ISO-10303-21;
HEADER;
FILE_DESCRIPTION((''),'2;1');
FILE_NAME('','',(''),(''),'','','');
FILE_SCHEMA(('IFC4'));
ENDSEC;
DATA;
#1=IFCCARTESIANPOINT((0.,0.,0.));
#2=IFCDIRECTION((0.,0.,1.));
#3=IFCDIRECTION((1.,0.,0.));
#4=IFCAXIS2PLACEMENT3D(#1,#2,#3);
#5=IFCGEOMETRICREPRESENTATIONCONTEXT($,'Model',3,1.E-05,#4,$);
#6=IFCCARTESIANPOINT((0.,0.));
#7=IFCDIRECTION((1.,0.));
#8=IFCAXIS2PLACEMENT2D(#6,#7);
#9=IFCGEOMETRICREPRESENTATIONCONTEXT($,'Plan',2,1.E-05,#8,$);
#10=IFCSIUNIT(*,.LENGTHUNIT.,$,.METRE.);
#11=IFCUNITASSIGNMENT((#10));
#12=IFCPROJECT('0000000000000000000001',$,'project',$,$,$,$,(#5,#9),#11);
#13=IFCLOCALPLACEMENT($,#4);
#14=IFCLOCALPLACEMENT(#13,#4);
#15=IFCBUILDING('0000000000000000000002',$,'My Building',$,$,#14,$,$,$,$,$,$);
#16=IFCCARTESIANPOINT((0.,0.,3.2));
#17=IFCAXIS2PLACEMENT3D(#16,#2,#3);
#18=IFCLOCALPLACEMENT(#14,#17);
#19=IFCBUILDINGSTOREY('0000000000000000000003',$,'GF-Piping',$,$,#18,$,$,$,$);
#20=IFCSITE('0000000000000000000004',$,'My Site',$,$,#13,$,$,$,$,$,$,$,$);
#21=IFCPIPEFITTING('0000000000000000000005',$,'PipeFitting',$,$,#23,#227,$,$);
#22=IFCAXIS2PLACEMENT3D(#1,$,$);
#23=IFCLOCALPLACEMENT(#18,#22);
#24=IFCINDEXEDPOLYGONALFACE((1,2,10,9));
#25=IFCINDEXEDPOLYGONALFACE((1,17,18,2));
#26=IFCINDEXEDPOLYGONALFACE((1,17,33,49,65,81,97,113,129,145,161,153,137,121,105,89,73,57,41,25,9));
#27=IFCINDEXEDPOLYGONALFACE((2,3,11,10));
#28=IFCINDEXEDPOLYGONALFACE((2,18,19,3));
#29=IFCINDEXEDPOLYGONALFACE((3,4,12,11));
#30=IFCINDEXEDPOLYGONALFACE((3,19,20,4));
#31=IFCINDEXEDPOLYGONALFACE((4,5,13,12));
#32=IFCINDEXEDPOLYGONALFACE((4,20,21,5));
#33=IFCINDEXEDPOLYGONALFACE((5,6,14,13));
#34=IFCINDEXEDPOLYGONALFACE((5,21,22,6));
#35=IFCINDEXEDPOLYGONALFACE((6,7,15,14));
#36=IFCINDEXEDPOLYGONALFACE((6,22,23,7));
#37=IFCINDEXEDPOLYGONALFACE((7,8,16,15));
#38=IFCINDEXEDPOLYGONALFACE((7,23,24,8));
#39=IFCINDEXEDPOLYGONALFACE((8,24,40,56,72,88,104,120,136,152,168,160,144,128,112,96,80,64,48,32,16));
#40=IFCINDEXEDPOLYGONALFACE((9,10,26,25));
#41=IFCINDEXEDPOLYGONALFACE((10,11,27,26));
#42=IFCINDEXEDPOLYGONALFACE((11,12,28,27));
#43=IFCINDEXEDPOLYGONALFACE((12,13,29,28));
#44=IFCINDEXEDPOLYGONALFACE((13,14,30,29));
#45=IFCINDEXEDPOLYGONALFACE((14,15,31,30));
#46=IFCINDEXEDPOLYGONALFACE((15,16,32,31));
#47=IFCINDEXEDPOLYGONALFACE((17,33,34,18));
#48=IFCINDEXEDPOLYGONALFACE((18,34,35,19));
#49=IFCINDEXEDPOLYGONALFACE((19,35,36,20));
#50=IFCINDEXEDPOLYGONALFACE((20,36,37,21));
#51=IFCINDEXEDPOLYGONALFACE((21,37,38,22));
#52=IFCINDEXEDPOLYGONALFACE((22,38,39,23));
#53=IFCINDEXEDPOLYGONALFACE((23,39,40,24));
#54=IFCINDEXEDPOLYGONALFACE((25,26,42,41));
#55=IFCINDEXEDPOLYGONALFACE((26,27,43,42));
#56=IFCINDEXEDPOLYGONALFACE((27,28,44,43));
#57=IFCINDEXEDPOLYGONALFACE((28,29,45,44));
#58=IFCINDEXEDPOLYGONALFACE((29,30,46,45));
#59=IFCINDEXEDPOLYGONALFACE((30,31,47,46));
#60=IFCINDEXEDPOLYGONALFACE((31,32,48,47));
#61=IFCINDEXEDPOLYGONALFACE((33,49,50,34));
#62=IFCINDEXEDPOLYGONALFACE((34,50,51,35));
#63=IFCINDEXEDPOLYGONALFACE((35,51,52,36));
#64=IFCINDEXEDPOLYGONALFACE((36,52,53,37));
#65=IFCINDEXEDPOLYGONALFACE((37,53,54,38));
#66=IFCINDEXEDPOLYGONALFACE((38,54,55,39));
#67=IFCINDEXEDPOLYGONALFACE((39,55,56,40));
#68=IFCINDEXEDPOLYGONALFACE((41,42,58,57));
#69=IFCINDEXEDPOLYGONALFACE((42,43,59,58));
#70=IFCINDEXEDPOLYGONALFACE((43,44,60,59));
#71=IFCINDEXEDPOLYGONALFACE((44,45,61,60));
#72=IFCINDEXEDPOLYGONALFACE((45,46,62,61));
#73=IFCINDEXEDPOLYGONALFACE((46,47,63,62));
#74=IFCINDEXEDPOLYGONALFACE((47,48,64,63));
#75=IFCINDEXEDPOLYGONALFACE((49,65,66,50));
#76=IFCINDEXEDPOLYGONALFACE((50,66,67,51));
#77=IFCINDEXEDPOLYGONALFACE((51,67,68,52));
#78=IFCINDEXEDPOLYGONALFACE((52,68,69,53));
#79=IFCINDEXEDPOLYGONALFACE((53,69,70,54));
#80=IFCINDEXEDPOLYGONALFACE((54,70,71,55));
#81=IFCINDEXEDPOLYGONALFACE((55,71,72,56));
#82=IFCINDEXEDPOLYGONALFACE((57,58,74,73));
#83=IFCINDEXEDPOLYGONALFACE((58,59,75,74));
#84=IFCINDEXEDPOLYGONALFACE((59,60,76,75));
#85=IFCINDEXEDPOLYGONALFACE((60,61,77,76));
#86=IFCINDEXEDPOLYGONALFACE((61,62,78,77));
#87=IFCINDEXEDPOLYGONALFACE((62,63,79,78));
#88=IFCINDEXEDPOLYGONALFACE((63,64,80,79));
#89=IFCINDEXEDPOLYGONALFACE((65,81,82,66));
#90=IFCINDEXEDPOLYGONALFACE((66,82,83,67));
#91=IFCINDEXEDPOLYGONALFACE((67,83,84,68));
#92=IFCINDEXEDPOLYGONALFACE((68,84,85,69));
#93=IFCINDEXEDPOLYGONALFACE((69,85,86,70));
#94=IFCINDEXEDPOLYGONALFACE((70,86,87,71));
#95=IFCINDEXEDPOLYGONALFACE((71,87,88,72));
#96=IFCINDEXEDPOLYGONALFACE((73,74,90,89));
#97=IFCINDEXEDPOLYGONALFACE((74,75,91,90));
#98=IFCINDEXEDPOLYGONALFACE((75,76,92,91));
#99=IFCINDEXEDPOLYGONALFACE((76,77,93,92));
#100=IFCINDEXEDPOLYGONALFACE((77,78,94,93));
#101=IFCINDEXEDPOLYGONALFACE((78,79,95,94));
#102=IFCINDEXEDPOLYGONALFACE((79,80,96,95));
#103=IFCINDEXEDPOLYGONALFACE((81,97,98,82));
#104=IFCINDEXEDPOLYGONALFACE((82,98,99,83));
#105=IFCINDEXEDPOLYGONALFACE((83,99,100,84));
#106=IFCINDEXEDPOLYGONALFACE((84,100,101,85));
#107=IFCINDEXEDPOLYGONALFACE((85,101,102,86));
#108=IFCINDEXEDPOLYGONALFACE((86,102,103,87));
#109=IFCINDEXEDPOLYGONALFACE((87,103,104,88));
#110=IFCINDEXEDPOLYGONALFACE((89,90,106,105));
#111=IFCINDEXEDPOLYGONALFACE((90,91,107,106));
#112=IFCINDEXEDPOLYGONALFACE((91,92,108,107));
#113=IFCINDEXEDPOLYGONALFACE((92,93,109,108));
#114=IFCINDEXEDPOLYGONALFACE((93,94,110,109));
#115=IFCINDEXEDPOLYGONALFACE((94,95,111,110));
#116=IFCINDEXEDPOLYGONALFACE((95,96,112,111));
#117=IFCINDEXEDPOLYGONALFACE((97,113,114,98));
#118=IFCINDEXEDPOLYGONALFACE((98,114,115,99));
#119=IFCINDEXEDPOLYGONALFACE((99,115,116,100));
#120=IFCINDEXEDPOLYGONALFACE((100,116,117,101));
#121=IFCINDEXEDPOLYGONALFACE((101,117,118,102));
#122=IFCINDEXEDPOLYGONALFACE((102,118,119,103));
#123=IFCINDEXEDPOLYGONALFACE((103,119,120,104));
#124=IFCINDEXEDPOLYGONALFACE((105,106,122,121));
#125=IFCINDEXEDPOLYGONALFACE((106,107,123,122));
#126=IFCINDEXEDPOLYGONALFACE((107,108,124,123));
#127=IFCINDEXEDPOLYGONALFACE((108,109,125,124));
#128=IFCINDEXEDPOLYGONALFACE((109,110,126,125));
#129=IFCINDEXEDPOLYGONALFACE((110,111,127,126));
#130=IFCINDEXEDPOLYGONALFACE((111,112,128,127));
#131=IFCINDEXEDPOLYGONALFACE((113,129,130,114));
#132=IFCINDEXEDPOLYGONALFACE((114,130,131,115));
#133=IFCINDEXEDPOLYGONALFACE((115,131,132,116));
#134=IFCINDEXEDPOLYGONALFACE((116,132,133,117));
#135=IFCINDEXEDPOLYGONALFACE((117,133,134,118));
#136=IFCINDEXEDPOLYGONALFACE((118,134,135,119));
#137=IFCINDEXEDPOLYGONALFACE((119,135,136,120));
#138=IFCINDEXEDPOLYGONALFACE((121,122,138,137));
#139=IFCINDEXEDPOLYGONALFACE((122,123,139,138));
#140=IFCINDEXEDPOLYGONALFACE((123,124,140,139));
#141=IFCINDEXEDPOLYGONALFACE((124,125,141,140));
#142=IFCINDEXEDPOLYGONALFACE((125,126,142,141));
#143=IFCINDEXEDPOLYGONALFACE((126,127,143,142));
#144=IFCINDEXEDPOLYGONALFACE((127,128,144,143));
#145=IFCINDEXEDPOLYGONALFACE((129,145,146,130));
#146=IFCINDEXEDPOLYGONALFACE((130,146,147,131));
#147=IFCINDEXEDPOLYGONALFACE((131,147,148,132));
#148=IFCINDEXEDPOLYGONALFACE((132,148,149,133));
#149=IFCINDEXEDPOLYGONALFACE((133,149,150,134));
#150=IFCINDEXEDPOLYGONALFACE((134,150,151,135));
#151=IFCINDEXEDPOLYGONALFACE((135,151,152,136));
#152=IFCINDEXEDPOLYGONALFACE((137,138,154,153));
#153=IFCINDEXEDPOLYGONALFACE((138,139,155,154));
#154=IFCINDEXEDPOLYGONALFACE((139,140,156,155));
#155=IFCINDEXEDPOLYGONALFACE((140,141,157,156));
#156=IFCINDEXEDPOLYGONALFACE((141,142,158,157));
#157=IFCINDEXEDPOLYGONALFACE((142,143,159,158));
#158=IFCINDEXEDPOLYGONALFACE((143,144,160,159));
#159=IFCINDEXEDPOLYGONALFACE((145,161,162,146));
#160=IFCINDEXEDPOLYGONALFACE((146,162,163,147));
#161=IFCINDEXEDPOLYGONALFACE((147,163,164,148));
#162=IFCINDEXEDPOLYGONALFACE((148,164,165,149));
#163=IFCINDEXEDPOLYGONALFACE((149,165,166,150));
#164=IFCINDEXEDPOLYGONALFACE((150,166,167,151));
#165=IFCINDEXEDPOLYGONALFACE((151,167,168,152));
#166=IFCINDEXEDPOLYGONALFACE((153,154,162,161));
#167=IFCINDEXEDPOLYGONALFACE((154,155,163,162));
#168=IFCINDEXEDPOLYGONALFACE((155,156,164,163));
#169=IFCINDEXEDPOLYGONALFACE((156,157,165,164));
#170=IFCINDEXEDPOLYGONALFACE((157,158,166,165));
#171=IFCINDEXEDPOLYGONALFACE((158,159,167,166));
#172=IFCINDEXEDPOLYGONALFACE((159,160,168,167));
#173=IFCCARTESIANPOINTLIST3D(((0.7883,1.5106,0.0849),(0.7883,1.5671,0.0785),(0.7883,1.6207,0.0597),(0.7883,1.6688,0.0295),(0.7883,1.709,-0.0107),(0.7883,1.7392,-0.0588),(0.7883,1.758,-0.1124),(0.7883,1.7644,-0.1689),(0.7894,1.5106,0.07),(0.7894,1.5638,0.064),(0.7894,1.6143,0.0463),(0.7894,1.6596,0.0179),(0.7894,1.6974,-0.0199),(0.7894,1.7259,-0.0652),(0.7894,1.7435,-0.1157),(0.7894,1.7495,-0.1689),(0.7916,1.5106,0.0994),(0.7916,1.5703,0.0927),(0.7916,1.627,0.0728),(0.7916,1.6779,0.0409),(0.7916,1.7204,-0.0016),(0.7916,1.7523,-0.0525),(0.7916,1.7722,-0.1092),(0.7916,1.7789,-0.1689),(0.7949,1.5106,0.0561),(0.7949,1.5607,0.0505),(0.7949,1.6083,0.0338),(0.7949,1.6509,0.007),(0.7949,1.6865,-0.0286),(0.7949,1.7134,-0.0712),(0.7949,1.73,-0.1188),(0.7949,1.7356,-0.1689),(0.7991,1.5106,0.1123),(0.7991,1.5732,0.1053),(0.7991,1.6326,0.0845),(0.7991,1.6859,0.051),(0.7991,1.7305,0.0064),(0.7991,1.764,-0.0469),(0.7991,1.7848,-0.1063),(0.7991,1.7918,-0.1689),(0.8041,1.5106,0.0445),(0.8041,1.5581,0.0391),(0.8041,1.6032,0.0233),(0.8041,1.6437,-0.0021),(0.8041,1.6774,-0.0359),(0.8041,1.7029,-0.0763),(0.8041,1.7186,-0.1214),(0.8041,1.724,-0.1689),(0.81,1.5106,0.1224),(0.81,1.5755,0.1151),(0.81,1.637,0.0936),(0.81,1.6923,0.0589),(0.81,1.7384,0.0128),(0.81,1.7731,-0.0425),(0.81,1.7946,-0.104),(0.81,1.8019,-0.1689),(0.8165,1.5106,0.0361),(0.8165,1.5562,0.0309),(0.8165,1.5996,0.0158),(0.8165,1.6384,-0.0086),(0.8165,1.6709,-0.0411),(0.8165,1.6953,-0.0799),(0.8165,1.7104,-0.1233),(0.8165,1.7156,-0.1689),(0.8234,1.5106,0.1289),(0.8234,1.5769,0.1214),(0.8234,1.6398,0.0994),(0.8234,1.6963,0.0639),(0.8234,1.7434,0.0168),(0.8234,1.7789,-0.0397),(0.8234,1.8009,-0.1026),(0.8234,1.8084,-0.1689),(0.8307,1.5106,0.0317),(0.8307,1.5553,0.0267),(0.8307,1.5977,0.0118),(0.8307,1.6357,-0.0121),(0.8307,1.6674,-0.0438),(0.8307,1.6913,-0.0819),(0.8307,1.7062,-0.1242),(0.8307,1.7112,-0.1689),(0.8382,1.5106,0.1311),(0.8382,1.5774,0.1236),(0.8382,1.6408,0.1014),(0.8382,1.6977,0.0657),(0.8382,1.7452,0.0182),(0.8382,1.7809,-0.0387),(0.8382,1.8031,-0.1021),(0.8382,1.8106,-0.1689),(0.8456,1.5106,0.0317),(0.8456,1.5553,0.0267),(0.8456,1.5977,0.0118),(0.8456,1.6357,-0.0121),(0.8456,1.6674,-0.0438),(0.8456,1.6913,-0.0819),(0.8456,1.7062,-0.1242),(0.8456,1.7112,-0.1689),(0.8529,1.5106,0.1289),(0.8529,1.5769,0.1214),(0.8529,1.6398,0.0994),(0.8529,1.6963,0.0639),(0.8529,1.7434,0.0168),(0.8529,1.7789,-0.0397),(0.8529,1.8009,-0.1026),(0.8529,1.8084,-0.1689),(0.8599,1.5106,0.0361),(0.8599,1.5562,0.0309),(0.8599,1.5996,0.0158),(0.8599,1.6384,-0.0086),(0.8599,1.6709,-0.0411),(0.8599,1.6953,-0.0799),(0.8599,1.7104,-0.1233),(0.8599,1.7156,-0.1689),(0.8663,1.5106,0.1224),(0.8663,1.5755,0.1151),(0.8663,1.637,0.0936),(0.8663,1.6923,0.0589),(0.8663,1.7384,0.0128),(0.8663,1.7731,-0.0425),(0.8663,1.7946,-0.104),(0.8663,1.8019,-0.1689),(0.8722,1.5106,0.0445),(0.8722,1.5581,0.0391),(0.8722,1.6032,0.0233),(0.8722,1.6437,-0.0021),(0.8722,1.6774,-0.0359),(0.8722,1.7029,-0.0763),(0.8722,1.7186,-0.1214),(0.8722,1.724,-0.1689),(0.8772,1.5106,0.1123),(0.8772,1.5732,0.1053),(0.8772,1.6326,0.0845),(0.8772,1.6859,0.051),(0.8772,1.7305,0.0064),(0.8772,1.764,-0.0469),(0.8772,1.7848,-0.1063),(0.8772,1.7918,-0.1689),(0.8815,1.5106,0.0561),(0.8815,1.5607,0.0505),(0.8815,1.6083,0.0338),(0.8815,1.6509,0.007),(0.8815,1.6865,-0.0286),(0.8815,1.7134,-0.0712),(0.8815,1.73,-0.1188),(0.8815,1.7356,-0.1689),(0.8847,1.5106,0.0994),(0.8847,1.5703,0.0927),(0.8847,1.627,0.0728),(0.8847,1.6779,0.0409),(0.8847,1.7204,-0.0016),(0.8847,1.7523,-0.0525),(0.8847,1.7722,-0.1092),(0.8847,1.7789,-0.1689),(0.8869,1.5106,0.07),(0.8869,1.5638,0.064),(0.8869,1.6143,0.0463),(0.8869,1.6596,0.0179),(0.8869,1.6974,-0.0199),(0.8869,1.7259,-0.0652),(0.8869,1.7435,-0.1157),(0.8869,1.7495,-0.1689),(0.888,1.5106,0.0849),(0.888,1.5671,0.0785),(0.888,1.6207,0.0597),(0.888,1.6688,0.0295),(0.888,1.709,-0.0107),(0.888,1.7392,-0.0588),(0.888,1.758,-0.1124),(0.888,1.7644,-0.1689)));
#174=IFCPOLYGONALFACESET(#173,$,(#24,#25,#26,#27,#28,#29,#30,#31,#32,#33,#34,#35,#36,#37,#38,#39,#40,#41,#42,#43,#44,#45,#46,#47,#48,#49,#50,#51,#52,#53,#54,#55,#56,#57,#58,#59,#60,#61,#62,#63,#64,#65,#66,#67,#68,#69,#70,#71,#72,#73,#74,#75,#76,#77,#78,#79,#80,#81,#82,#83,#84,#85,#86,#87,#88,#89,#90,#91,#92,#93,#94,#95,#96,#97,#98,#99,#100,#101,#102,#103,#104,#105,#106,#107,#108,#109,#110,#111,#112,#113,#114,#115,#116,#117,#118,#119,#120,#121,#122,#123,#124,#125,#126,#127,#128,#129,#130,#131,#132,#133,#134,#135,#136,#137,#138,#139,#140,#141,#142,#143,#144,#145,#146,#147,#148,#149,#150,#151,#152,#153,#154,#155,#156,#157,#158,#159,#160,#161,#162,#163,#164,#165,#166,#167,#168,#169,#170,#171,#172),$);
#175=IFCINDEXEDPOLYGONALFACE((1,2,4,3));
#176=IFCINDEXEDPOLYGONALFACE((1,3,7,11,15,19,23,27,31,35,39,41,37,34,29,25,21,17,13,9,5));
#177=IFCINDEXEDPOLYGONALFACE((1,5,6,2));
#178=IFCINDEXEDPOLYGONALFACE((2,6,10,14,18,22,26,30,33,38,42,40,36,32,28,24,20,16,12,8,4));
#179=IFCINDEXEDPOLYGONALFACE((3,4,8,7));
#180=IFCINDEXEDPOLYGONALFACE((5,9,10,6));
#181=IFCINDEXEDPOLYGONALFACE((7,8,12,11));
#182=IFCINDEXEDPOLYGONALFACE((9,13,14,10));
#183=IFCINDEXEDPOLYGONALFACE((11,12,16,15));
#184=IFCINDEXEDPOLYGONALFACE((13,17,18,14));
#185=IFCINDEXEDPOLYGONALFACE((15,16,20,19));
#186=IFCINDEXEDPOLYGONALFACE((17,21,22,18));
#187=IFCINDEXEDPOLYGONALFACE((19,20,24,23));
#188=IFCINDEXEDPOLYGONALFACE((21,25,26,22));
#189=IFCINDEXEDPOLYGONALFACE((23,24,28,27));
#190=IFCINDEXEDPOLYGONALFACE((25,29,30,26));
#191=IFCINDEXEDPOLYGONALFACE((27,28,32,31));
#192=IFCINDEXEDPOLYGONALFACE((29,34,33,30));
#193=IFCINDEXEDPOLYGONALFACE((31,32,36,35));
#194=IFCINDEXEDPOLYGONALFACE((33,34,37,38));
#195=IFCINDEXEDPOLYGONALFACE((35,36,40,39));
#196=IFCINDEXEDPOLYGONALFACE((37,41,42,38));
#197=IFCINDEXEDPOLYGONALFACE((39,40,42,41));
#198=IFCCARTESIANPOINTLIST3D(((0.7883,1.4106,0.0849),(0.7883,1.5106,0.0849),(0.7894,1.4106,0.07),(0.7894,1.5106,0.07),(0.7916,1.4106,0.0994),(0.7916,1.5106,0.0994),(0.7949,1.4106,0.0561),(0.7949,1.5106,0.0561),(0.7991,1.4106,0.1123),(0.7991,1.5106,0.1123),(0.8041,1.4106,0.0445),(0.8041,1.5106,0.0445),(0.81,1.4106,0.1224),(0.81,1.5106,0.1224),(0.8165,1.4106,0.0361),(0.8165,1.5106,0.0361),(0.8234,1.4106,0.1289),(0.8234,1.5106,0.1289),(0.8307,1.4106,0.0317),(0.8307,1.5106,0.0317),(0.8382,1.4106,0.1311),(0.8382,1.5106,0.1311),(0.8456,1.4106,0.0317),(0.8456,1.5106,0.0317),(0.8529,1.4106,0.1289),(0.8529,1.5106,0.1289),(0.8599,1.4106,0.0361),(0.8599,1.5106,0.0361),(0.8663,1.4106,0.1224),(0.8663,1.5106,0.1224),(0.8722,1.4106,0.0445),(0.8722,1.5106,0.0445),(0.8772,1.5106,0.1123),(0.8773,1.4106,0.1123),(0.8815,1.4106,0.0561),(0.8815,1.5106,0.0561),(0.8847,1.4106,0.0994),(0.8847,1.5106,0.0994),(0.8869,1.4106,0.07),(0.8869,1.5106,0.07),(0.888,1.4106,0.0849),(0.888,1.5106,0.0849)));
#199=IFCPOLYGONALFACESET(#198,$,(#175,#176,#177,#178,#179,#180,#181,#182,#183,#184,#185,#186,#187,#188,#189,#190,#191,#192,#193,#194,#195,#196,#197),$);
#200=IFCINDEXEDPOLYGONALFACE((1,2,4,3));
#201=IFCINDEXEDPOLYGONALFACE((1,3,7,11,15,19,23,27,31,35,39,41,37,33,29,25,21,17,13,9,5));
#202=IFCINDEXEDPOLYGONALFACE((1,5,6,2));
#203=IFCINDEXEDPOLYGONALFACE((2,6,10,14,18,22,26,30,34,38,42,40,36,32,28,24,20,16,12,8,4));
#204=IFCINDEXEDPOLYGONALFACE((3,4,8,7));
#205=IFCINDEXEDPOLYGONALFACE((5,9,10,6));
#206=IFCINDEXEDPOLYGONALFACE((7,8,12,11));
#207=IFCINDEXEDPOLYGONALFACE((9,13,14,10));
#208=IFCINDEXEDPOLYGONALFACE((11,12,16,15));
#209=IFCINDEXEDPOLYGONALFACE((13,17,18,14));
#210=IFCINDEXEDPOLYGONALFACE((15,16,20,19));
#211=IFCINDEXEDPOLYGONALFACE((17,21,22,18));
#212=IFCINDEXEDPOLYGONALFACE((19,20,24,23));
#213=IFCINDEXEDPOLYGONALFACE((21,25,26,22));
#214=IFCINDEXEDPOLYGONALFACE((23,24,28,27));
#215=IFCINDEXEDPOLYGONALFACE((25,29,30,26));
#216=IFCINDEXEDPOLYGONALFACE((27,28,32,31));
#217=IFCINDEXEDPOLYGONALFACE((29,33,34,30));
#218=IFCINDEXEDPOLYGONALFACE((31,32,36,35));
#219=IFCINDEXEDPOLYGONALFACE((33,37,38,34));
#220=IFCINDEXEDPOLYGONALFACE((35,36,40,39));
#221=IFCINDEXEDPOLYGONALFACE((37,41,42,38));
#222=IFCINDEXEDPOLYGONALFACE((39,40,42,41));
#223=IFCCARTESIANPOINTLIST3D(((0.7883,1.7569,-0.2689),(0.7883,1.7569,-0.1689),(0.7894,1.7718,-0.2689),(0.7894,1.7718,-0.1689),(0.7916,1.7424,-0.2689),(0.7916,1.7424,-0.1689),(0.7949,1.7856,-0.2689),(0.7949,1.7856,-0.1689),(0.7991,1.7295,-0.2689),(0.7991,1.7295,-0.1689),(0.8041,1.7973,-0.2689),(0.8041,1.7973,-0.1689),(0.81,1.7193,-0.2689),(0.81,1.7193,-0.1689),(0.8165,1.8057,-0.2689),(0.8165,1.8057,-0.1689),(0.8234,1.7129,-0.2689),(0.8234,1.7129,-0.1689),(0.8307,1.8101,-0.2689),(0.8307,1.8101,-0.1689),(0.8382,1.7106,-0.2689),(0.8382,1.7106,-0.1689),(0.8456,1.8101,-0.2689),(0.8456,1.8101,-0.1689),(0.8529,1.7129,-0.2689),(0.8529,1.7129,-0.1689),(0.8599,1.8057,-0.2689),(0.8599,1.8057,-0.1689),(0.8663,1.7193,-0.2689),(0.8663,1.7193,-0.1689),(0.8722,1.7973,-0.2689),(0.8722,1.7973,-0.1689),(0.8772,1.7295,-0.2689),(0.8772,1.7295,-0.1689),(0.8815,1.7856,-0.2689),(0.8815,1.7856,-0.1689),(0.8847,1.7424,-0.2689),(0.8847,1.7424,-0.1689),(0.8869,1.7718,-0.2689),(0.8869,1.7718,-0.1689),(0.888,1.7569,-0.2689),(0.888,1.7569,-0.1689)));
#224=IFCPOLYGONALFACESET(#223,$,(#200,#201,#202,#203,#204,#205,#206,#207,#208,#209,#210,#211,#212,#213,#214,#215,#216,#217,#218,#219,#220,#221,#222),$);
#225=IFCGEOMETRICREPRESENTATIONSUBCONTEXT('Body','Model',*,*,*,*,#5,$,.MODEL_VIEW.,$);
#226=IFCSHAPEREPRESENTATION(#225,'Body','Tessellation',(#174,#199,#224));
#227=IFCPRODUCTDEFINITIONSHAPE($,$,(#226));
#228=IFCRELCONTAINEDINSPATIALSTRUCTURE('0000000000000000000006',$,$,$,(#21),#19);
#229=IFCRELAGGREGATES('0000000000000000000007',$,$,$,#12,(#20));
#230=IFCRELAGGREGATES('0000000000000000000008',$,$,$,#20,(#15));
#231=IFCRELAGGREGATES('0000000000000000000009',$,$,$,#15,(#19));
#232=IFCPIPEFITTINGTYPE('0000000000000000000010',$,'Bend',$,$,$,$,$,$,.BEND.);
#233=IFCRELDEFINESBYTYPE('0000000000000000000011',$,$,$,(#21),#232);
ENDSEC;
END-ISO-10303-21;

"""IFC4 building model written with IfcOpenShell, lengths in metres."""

from ifc_helpers import new_model, entity, si_unit, frame, origin_with_axes, origin_2d_with_axis, place, context, subcontext, project, spatial, circle, extrude, source, transform, mapped, type_object, type_shapes, element, save


model = new_model("IFC4")

# Units and contexts
model_context = context("Model", 3, precision=1e-05, world=origin_with_axes())
plan_context = context("Plan", 2, precision=1e-05, world=origin_2d_with_axis())
body_context = subcontext(model_context, "Body", "Model", "MODEL_VIEW")
ifc_project = project(units=[si_unit("LENGTHUNIT", "METRE")], contexts=[model_context, plan_context])

# Site, building, storey
site_placement = place(None, origin_with_axes())
site = spatial("IfcSite", under=ifc_project, at=site_placement, Name="My Site")
building_placement = place(site_placement, origin_with_axes())
building = spatial("IfcBuilding", under=site, at=building_placement, Name="My Building")
storey_placement = place(building_placement, frame((0.0, 0.0, 3.2), z_axis=(0.0, 0.0, 1.0), x_axis=(1.0, 0.0, 0.0)))
storey = spatial("IfcBuildingStorey", under=building, at=storey_placement, Name="GF-Piping")

# Pipe fitting
pipe_fitting_type = type_object("IfcPipeFittingType", Name="Bend", PredefinedType="BEND")
shared_shape = source(origin_with_axes(), body_context, "Body", "SolidModel", [
    entity("IfcSweptDiskSolid", entity("IfcIndexedPolyCurve", entity("IfcCartesianPointList3D", [[0.0, 0.0, 0.1], [-0.0732, 0.0, 0.2768], [-0.25, 0.0, 0.35]]), [entity("IfcArcIndex", [1, 2, 3])]), 0.05),
    extrude(circle(Radius=0.05), origin_with_axes(), (0.0, 0.0, 1.0), 0.1),
    extrude(circle(Radius=0.05), frame((-0.25, 0.0, 0.35), z_axis=(-1.0, 0.0, 0.0), x_axis=(0.0, 0.0, -1.0)), (0.0, 0.0, 1.0), 0.1),
])
type_shapes(pipe_fitting_type, [shared_shape])
for number, where, z_axis, x_axis, name in (
    (1, (0.8382, 1.4106, 0.0811), (0.0, 1.0, 0.0), (0.0, 0.0, 1.0), "PipeFitting"),
):
    element("IfcPipeFitting", number, at=place(storey_placement, frame(where, z_axis=z_axis, x_axis=x_axis)), inside=storey, type_object=pipe_fitting_type, Name=name, context=body_context, shape_type="MappedRepresentation", body=[
        mapped(shared_shape, transform((0.0, 0.0, 0.0), x_axis=(1.0, 0.0, 0.0), y_axis=(0.0, 1.0, 0.0), z_axis=(0.0, 0.0, 1.0), scale=1.0)),
    ])

save(model, "model.ifc")
